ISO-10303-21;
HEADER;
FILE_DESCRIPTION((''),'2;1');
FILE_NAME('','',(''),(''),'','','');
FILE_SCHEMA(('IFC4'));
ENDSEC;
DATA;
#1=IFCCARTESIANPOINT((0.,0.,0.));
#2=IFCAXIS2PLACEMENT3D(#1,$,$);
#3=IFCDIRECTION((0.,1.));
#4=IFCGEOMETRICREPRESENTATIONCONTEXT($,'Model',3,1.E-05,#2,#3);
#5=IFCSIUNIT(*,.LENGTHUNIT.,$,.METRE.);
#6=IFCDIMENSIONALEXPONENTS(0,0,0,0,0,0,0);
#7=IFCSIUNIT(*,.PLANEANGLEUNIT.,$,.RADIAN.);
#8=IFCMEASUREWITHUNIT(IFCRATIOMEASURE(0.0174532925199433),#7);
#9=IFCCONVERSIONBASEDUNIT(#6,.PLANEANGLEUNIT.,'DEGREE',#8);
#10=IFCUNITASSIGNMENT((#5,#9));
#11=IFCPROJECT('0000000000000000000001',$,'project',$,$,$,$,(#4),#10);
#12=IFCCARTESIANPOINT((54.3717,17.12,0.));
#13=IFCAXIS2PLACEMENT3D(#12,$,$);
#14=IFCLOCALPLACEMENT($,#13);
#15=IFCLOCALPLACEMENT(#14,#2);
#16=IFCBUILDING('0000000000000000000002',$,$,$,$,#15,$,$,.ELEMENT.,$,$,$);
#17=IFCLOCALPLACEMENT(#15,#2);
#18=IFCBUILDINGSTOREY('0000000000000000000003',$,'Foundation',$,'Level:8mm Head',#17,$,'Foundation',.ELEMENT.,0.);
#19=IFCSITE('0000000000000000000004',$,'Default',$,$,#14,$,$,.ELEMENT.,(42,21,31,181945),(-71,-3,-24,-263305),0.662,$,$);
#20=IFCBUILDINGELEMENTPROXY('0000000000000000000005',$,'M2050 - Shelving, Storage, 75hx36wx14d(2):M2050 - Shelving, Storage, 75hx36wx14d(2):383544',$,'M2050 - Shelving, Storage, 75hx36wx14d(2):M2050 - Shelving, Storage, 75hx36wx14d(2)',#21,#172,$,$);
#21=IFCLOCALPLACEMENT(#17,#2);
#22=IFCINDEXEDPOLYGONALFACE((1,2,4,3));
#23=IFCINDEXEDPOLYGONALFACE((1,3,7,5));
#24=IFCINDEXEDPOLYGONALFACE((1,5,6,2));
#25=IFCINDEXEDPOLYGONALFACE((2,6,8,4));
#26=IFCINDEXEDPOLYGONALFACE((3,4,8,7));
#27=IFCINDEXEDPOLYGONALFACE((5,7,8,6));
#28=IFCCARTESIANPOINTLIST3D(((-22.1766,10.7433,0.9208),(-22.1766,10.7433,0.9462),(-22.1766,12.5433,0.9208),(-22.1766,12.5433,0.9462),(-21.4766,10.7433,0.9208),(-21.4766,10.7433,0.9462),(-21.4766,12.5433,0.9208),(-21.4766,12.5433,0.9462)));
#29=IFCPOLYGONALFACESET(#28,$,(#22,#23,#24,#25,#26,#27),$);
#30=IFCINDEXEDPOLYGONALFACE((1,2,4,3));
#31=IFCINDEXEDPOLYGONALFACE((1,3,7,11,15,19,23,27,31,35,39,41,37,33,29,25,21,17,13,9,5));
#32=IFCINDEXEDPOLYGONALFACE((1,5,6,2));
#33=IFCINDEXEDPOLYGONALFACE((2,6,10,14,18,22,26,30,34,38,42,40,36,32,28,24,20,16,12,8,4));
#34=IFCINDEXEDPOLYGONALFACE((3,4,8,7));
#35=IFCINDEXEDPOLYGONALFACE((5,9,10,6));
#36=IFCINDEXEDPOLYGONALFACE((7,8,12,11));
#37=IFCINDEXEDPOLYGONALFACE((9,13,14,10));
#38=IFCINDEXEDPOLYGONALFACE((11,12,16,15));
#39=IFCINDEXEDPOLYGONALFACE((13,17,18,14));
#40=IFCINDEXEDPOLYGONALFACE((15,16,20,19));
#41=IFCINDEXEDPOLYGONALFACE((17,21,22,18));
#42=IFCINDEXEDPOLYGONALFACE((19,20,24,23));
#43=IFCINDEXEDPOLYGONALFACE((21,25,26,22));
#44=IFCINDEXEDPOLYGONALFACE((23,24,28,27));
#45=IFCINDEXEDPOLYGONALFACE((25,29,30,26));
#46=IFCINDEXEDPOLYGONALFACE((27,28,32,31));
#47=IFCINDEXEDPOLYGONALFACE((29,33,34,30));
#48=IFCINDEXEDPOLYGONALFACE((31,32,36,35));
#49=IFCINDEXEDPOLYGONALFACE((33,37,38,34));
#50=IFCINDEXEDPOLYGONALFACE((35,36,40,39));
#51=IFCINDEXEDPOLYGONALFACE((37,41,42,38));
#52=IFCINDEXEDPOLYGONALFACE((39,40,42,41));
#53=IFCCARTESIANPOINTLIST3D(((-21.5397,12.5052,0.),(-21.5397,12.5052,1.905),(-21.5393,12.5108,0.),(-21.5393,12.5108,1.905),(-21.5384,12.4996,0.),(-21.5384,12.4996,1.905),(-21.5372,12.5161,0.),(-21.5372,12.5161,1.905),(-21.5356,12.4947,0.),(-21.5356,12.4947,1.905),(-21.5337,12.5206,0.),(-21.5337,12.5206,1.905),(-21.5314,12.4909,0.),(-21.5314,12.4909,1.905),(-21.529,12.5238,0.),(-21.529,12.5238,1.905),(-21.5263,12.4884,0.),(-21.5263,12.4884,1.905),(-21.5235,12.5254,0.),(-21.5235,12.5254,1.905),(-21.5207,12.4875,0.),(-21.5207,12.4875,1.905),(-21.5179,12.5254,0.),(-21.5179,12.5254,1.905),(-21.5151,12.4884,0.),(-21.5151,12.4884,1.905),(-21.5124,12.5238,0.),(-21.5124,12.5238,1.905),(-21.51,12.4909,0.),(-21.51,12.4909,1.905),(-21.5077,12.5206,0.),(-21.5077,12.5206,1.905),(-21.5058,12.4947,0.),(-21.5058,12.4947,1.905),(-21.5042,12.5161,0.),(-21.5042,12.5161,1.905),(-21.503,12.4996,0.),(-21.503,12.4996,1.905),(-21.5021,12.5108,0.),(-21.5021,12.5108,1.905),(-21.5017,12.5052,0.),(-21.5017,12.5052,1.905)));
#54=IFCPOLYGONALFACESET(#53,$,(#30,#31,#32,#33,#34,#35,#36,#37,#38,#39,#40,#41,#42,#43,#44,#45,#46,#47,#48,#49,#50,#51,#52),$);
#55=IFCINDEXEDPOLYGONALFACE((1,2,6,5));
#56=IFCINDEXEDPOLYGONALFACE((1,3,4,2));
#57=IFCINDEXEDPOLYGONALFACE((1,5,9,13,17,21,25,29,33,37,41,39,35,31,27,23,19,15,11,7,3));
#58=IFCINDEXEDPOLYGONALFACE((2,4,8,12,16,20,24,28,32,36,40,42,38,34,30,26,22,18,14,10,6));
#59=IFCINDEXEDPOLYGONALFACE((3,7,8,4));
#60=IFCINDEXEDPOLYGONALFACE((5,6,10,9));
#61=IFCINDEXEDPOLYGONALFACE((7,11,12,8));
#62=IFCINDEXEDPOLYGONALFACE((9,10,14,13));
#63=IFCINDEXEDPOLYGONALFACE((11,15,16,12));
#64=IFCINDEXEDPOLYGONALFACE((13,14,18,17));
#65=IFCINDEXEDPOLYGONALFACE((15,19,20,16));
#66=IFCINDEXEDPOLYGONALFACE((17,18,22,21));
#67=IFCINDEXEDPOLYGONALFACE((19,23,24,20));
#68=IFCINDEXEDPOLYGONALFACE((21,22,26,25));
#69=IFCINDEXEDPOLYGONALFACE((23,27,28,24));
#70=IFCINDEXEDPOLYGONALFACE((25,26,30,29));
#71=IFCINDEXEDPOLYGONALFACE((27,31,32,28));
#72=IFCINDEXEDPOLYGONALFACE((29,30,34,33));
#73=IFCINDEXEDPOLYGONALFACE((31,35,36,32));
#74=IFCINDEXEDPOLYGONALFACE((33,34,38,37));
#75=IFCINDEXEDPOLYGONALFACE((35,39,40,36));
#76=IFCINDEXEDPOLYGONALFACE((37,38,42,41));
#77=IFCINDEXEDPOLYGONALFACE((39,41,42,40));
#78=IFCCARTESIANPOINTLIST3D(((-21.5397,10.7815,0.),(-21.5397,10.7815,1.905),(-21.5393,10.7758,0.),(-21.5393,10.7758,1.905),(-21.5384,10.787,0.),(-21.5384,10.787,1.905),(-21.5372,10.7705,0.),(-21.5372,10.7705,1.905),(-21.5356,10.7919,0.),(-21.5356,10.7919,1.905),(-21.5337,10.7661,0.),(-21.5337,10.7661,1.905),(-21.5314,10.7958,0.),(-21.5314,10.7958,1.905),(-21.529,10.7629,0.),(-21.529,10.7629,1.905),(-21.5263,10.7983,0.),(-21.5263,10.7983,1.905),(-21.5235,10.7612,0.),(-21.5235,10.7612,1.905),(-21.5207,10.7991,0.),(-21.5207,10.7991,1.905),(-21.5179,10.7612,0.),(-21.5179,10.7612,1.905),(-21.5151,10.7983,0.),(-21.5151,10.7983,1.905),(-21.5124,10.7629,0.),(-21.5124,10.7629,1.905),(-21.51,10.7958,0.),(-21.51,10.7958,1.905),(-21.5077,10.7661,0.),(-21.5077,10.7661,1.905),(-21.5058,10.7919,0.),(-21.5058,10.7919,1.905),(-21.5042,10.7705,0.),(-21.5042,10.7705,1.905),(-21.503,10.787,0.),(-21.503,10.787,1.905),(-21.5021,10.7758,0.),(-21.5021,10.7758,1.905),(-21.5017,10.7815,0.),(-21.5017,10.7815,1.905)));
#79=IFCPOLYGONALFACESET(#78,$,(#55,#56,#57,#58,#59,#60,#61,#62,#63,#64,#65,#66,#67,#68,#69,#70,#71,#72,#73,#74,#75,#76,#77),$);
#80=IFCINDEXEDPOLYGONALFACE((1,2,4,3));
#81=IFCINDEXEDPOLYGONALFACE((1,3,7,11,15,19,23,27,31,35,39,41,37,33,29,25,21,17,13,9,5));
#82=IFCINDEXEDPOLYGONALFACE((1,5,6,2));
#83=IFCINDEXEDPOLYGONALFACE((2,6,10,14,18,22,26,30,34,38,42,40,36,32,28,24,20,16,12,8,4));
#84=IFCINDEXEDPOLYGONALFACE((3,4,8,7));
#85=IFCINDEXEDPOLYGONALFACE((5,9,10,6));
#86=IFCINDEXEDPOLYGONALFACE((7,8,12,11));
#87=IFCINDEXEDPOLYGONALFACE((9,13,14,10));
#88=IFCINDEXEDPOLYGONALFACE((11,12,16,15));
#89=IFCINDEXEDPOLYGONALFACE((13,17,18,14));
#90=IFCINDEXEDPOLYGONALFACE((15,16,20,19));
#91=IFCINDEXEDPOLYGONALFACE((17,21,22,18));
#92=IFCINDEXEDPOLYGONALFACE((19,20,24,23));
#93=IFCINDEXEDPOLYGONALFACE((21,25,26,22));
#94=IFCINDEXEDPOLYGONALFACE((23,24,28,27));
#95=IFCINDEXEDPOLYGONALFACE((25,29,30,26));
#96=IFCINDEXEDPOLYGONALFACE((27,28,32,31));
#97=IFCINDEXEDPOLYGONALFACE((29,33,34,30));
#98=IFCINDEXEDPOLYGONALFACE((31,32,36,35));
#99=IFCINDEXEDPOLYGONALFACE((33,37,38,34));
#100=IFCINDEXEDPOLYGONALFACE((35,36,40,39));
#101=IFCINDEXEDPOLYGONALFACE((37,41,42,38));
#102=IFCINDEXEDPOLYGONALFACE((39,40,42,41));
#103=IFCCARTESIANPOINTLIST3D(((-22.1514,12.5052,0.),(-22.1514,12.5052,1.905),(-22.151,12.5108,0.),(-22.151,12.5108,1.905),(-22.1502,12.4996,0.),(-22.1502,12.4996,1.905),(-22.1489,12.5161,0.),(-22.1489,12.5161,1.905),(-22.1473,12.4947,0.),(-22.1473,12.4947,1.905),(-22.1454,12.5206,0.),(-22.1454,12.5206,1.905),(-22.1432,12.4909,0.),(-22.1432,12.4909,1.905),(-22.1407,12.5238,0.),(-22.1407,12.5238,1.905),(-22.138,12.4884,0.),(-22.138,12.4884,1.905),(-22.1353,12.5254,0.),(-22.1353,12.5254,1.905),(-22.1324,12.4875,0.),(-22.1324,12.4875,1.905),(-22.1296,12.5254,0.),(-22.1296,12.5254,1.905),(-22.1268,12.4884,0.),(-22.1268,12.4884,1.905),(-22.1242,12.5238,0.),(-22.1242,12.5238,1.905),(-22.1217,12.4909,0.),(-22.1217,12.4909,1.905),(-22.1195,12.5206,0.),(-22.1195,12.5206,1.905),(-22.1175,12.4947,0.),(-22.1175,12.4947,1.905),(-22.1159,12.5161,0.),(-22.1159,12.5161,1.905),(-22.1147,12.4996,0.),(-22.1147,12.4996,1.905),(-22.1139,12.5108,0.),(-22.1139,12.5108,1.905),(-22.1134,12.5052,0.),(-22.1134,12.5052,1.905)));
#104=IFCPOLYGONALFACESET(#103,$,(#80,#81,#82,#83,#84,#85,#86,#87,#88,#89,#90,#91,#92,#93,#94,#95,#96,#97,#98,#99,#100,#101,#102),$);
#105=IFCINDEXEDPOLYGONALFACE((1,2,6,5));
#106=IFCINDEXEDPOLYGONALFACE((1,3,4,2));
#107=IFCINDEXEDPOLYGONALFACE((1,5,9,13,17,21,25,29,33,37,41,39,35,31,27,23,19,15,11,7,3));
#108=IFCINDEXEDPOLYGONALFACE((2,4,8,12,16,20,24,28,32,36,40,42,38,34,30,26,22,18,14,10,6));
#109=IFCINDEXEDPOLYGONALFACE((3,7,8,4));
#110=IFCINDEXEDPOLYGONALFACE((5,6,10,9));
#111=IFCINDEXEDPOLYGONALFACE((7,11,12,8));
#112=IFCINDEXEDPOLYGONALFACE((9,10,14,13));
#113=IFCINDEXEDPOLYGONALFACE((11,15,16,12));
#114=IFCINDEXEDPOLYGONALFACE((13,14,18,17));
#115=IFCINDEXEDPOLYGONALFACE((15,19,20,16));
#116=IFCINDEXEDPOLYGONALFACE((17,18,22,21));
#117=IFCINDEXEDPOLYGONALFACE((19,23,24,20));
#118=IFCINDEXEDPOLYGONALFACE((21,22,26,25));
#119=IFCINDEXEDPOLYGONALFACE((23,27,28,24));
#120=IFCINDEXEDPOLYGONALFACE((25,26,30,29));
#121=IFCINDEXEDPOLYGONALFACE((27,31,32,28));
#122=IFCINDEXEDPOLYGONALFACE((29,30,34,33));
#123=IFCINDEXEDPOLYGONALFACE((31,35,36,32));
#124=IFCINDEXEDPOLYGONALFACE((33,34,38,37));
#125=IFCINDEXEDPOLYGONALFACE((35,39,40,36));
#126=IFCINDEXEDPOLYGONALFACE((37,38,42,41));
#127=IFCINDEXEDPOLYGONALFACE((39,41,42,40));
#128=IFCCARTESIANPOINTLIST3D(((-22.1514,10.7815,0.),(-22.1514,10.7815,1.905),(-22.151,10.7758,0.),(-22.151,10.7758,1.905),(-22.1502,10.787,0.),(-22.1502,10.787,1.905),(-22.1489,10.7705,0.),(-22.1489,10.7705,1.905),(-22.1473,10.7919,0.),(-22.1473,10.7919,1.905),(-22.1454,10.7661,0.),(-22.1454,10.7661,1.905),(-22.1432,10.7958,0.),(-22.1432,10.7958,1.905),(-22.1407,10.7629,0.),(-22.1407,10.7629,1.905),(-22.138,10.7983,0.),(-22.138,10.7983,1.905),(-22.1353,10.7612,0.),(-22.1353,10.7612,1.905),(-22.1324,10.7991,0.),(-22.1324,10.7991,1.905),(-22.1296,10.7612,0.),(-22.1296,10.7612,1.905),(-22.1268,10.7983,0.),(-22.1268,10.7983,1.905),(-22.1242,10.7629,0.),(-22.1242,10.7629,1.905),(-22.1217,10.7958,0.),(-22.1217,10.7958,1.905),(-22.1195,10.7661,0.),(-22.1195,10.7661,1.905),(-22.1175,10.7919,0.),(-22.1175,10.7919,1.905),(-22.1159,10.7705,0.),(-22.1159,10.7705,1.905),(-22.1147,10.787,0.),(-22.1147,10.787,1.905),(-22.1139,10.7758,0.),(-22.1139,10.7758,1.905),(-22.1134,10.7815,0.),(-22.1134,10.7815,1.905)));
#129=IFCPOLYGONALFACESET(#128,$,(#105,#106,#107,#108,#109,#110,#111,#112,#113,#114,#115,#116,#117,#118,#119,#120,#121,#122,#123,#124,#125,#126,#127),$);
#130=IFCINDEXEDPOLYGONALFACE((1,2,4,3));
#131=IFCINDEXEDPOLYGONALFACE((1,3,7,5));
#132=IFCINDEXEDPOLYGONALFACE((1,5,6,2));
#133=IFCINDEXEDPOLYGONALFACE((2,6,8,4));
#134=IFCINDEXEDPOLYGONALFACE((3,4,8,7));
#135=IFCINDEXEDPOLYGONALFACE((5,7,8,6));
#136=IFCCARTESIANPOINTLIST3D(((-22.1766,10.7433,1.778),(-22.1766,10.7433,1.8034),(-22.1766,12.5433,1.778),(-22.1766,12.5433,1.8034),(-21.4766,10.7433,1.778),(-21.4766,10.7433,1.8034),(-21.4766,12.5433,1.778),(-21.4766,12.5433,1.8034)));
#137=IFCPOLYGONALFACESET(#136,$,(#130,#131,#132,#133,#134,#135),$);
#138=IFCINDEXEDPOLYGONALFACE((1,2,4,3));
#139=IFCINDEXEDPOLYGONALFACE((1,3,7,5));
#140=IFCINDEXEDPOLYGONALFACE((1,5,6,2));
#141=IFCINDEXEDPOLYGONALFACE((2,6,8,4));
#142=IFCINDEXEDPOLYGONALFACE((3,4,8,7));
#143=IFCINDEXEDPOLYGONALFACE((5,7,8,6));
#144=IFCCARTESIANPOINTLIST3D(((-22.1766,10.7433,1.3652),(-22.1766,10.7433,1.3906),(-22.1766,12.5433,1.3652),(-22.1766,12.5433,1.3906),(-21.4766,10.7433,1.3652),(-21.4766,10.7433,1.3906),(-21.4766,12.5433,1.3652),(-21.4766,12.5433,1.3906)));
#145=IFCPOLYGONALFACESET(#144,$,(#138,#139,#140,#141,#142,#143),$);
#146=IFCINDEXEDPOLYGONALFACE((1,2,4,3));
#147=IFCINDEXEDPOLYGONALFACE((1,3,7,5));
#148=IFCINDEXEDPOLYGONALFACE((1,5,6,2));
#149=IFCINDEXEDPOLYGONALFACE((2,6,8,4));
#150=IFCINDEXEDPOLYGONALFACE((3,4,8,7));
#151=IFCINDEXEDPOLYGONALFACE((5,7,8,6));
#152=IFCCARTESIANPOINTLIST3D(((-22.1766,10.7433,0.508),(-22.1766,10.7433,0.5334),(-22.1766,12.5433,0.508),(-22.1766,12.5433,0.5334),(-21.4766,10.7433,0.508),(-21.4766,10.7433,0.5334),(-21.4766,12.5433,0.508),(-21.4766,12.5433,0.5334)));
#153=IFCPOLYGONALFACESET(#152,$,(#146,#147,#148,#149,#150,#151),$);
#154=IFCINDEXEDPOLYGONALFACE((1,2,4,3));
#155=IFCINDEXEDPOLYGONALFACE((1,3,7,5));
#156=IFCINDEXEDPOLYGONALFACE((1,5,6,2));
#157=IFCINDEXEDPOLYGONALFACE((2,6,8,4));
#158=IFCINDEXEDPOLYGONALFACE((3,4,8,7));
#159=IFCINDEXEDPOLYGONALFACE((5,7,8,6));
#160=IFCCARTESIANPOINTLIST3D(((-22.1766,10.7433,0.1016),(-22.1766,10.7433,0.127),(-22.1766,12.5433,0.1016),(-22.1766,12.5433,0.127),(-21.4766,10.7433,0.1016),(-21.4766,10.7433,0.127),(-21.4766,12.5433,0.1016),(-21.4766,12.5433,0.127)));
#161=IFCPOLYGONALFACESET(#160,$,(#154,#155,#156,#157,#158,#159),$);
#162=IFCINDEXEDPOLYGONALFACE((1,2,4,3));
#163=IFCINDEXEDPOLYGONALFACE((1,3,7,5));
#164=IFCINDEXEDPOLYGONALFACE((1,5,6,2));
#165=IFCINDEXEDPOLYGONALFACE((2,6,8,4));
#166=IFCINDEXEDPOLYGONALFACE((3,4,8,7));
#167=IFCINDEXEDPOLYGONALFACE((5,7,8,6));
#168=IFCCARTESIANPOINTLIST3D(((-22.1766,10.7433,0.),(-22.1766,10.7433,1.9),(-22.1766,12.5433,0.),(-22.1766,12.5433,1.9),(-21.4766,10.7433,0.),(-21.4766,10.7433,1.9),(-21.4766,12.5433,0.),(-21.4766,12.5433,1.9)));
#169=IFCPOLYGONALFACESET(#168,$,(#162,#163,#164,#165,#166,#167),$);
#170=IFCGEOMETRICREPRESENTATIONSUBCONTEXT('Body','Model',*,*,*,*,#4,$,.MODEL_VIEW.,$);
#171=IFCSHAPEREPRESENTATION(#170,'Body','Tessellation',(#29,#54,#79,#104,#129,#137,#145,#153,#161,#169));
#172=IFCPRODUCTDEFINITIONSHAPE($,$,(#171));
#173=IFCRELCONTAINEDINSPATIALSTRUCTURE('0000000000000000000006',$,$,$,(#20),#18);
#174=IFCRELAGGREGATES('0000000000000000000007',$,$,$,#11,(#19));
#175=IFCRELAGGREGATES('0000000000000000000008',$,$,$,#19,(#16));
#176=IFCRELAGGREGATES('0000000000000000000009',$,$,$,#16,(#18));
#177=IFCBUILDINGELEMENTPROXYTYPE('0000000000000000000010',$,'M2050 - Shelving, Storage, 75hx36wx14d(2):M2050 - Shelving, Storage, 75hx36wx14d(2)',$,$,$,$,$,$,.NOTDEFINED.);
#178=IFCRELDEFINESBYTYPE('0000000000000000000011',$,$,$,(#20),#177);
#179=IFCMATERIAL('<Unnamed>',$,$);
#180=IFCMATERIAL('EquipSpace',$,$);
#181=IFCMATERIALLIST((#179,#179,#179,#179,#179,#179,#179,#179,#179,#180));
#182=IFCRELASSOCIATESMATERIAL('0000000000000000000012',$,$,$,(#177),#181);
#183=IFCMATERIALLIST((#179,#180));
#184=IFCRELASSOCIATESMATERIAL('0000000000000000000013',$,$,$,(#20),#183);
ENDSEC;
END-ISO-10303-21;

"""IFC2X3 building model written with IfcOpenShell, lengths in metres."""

from ifc_helpers import new_model, entity, si_unit, converted_unit, direction, frame, frame_2d, origin, origin_2d_with_axis, place, context, subcontext, project, spatial, rectangle, circle, extrude, source, transform, mapped, material, material_list, type_object, type_shapes, element, save


model = new_model("IFC2X3")

# Units and contexts
model_context = context("Model", 3, precision=1e-05, world=origin(), true_north=direction((0.0, 1.0)))
body_context = subcontext(model_context, "Body", "Model", "MODEL_VIEW")
ifc_project = project(units=[si_unit("LENGTHUNIT", "METRE"), converted_unit("PLANEANGLEUNIT", "DEGREE", entity("IfcRatioMeasure", 0.0174532925199433), si_unit("PLANEANGLEUNIT", "RADIAN"), dimensions=[0, 0, 0, 0, 0, 0, 0])], contexts=[model_context])

# Site, building, storey
site_placement = place(None, frame((54.3717, 17.12, 0.0)))
site = spatial("IfcSite", under=ifc_project, at=site_placement, Name="Default", CompositionType="ELEMENT", RefLatitude=(42, 21, 31, 181945), RefLongitude=(-71, -3, -24, -263305), RefElevation=0.662)
building_placement = place(site_placement, origin())
building = spatial("IfcBuilding", under=site, at=building_placement, CompositionType="ELEMENT")
storey_placement = place(building_placement, origin())
storey = spatial("IfcBuildingStorey", under=building, at=storey_placement, Name="Foundation", ObjectType="Level:8mm Head", LongName="Foundation", CompositionType="ELEMENT", Elevation=0.0)

# Building element proxy
ifc_material_1 = material(Name="<Unnamed>")
ifc_material_2 = material(Name="EquipSpace")
ifc_material_list_1 = material_list([ifc_material_1, ifc_material_1, ifc_material_1, ifc_material_1, ifc_material_1, ifc_material_1, ifc_material_1, ifc_material_1, ifc_material_1, ifc_material_2])
building_element_proxy_type = type_object("IfcBuildingElementProxyType", Name="M2050 - Shelving, Storage, 75hx36wx14d(2):M2050 - Shelving, Storage, 75hx36wx14d(2)", PredefinedType="NOTDEFINED", material=ifc_material_list_1)
shared_shape = source(origin(), body_context, "Body", "SweptSolid", [
    extrude(rectangle(XDim=1.8, YDim=0.7, at=origin_2d_with_axis()), frame((0.0, 0.0, 0.9207), z_axis=(0.0, 0.0, 1.0), x_axis=(-1.0, 0.0, 0.0)), (0.0, 0.0, 1.0), 0.0254),
    extrude(circle(Radius=0.0191, at=origin_2d_with_axis()), frame((0.8633, -0.3059, 0.0), z_axis=(0.0, 0.0, 1.0), x_axis=(-1.0, 0.0, 0.0)), (0.0, 0.0, 1.0), 1.905),
    extrude(circle(Radius=0.0191, at=origin_2d_with_axis()), frame((-0.8633, -0.3059, 0.0)), (0.0, 0.0, 1.0), 1.905),
    extrude(circle(Radius=0.0191, at=origin_2d_with_axis()), frame((0.8633, 0.3059, 0.0), z_axis=(0.0, 0.0, 1.0), x_axis=(-1.0, 0.0, 0.0)), (0.0, 0.0, 1.0), 1.905),
    extrude(circle(Radius=0.0191, at=origin_2d_with_axis()), frame((-0.8633, 0.3059, 0.0)), (0.0, 0.0, 1.0), 1.905),
    extrude(rectangle(XDim=1.8, YDim=0.7, at=origin_2d_with_axis()), frame((0.0, 0.0, 1.778), z_axis=(0.0, 0.0, 1.0), x_axis=(-1.0, 0.0, 0.0)), (0.0, 0.0, 1.0), 0.0254),
    extrude(rectangle(XDim=1.8, YDim=0.7, at=origin_2d_with_axis()), frame((0.0, 0.0, 1.3653), z_axis=(0.0, 0.0, 1.0), x_axis=(-1.0, 0.0, 0.0)), (0.0, 0.0, 1.0), 0.0254),
    extrude(rectangle(XDim=1.8, YDim=0.7, at=origin_2d_with_axis()), frame((0.0, 0.0, 0.508), z_axis=(0.0, 0.0, 1.0), x_axis=(-1.0, 0.0, 0.0)), (0.0, 0.0, 1.0), 0.0254),
    extrude(rectangle(XDim=1.8, YDim=0.7, at=origin_2d_with_axis()), frame((0.0, 0.0, 0.1016), z_axis=(0.0, 0.0, 1.0), x_axis=(-1.0, 0.0, 0.0)), (0.0, 0.0, 1.0), 0.0254),
    extrude(rectangle(XDim=0.7, YDim=1.8, at=frame_2d((0.0, 0.18), x_axis=(1.0, 0.0))), frame((-0.18, 0.0, 0.0), z_axis=(0.0, 0.0, 1.0), x_axis=(0.0, -1.0, 0.0)), (0.0, 0.0, 1.0), 1.9),
])
type_shapes(building_element_proxy_type, [shared_shape])
ifc_material_list_2 = material_list([ifc_material_1, ifc_material_2])
proxy_1_placement = place(storey_placement, frame((-21.8266, 11.6433, 0.0), z_axis=(0.0, 0.0, 1.0), x_axis=(0.0, 1.0, 0.0)))
element("IfcBuildingElementProxy", 1, at=proxy_1_placement, inside=storey, type_object=building_element_proxy_type, material=ifc_material_list_2, Name="M2050 - Shelving, Storage, 75hx36wx14d(2):M2050 - Shelving, Storage, 75hx36wx14d(2):383544", ObjectType="M2050 - Shelving, Storage, 75hx36wx14d(2):M2050 - Shelving, Storage, 75hx36wx14d(2)", context=body_context, shape_type="MappedRepresentation", body=[
    mapped(shared_shape, transform((0.0, 0.0, 0.0), scale=1.0)),
])

save(model, "model.ifc")
